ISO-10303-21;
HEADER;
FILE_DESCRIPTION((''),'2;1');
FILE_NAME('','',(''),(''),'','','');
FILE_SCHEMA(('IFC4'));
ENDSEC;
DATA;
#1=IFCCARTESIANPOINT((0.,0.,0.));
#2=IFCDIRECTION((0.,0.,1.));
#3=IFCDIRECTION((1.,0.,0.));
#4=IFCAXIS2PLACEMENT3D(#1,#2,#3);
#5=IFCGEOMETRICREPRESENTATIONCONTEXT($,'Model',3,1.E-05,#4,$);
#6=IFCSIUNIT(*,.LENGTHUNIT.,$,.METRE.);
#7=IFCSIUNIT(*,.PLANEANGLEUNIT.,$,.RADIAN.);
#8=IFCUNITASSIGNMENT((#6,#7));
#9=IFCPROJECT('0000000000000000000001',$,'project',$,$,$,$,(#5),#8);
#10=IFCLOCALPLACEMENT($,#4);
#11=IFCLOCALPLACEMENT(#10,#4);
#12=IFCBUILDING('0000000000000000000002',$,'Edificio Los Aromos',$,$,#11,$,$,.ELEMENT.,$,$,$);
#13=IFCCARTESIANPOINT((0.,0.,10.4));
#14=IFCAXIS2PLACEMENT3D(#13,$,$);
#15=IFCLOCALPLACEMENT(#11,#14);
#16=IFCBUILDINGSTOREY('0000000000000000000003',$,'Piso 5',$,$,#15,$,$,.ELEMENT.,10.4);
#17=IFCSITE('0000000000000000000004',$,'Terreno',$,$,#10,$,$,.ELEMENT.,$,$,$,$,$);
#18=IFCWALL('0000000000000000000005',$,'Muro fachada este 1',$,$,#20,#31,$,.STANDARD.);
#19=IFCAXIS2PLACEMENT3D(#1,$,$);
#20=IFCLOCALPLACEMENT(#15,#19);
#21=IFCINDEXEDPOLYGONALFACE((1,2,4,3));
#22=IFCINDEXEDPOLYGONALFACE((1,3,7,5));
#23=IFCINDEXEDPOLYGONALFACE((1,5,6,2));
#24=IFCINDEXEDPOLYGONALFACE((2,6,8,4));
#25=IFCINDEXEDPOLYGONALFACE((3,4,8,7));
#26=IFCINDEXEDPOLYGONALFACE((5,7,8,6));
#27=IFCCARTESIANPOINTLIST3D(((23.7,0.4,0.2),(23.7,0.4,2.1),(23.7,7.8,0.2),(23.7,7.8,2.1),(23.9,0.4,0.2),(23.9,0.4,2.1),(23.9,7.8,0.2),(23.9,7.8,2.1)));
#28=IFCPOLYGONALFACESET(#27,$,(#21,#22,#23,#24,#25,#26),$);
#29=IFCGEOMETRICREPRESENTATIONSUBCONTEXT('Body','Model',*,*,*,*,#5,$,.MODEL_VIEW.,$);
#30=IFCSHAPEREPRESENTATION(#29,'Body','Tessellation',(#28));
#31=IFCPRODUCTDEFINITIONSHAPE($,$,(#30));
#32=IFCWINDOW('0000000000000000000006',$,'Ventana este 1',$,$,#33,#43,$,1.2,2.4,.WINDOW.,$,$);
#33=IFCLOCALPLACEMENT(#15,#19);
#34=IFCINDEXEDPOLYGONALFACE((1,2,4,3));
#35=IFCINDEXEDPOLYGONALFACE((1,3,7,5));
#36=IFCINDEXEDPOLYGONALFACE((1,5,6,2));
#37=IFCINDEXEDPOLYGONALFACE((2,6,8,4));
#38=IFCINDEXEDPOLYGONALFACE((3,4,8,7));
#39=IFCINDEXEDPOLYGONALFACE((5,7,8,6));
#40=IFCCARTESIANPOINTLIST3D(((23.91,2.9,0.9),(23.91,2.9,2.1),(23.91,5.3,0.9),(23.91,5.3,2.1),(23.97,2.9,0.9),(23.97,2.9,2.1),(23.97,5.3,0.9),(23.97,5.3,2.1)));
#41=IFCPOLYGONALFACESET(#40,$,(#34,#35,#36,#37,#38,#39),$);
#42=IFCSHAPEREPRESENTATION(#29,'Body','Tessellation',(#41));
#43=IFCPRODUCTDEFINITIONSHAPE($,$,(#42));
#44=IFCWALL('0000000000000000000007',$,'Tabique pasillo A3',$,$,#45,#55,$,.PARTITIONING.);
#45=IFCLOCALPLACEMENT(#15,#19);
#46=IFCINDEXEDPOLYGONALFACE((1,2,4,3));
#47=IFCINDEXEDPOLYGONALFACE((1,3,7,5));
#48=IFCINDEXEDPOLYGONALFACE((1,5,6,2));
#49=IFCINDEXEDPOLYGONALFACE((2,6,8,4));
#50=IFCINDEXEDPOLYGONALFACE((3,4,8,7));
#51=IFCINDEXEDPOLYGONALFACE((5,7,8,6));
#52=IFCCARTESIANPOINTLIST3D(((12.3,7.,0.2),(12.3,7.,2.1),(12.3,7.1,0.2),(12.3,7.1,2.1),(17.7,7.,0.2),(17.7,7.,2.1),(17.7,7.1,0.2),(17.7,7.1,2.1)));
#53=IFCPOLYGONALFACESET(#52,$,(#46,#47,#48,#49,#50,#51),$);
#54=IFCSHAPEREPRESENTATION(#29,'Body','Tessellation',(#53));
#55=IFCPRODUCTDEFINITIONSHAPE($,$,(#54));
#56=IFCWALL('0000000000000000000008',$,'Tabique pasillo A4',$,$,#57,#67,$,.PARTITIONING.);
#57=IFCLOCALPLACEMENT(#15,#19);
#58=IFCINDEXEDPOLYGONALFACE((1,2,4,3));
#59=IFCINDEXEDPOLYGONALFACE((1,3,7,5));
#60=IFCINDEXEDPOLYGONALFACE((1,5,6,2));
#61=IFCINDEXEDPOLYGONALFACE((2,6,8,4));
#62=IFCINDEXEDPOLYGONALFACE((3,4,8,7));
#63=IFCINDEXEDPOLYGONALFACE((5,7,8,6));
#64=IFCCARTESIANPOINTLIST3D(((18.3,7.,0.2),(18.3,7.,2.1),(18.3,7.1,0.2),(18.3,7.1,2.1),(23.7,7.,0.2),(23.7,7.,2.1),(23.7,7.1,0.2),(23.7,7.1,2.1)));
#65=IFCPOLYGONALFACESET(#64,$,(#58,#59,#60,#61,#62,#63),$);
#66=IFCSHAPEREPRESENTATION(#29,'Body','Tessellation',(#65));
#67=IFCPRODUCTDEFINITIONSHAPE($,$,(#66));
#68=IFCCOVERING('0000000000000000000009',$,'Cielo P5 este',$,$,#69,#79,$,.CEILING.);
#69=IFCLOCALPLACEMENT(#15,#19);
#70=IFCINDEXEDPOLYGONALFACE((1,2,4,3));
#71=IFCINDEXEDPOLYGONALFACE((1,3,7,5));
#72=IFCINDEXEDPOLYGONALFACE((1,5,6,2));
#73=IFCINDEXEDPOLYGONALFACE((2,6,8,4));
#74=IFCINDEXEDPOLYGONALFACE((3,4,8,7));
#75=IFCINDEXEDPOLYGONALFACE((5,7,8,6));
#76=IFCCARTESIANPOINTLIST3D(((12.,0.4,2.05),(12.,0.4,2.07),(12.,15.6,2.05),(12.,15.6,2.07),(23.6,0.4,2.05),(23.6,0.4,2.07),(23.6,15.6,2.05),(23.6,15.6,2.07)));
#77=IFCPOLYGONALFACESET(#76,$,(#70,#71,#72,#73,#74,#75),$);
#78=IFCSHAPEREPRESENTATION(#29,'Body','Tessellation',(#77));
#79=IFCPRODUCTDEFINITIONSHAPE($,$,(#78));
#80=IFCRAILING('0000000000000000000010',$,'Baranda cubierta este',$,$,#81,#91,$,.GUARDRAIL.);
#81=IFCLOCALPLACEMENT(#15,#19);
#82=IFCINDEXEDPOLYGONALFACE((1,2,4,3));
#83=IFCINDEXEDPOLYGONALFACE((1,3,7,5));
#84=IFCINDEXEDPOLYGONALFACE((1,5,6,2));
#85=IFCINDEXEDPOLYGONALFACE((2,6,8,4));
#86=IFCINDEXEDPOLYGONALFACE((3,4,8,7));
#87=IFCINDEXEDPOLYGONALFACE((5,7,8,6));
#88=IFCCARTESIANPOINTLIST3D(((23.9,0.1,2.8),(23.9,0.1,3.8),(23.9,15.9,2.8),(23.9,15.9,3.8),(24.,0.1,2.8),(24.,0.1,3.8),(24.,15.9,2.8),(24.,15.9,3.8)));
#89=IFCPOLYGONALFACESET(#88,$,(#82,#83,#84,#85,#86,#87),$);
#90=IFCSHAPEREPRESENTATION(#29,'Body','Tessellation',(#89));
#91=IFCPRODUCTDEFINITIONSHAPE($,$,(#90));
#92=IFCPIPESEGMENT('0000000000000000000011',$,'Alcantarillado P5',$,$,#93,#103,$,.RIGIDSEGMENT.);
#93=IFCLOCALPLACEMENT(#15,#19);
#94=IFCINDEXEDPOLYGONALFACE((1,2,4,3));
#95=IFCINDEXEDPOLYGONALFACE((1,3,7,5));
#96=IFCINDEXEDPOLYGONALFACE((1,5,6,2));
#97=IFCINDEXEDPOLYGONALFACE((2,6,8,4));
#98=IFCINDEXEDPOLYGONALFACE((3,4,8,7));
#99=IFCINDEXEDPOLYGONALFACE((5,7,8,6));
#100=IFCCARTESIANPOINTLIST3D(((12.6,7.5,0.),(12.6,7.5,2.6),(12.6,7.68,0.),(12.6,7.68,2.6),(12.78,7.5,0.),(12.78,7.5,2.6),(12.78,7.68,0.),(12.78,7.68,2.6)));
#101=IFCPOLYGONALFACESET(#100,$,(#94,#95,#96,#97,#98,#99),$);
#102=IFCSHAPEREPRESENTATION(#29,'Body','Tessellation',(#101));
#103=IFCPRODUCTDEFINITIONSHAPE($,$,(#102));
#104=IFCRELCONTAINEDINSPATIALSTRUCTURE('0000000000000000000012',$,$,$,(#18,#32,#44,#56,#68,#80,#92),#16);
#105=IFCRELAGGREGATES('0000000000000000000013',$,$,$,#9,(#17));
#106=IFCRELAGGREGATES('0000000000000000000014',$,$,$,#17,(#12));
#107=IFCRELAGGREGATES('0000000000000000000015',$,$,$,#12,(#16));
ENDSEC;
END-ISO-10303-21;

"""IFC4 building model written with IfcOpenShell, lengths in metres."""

from ifc_helpers import new_model, si_unit, frame, frame_2d, origin_with_axes, place, context, subcontext, project, spatial, rectangle, extrude, element, save


model = new_model("IFC4")

# Units and contexts
model_context = context("Model", 3, precision=1e-05, world=origin_with_axes())
body_context = subcontext(model_context, "Body", "Model", "MODEL_VIEW")
ifc_project = project(units=[si_unit("LENGTHUNIT", "METRE"), si_unit("PLANEANGLEUNIT", "RADIAN")], contexts=[model_context])

# Site, building, storey
site_placement = place(None, origin_with_axes())
site = spatial("IfcSite", under=ifc_project, at=site_placement, Name="Terreno", CompositionType="ELEMENT")
building_placement = place(site_placement, origin_with_axes())
building = spatial("IfcBuilding", under=site, at=building_placement, Name="Edificio Los Aromos", CompositionType="ELEMENT")
storey_placement = place(building_placement, frame((0.0, 0.0, 10.4)))
storey = spatial("IfcBuildingStorey", under=building, at=storey_placement, Name="Piso 5", CompositionType="ELEMENT", Elevation=10.4)

# Wall
wall_1_placement = place(storey_placement, frame((23.7, 0.4, 0.2)))
element("IfcWall", 1, at=wall_1_placement, inside=storey, Name="Muro fachada este 1", PredefinedType="STANDARD", context=body_context, shape_type="SweptSolid", body=[
    extrude(rectangle(XDim=0.2, YDim=7.4, at=frame_2d((0.1, 3.7))), origin_with_axes(), (0.0, 0.0, 1.0), 1.9),
])

# Window
window_1_placement = place(storey_placement, frame((23.91, 2.9, 0.9)))
element("IfcWindow", 2, at=window_1_placement, inside=storey, Name="Ventana este 1", OverallHeight=1.2, OverallWidth=2.4, PredefinedType="WINDOW", context=body_context, shape_type="SweptSolid", body=[
    extrude(rectangle(XDim=0.06, YDim=2.4, at=frame_2d((0.03, 1.2))), origin_with_axes(), (0.0, 0.0, 1.0), 1.2),
])

# Walls
for number, where, name in (
    (3, (12.3, 7.0, 0.2), "Tabique pasillo A3"),
    (4, (18.3, 7.0, 0.2), "Tabique pasillo A4"),
):
    element("IfcWall", number, at=place(storey_placement, frame(where)), inside=storey, Name=name, PredefinedType="PARTITIONING", context=body_context, shape_type="SweptSolid", body=[
        extrude(rectangle(XDim=5.4, YDim=0.1, at=frame_2d((2.7, 0.05))), origin_with_axes(), (0.0, 0.0, 1.0), 1.9),
    ])

# Covering
covering_placement = place(storey_placement, frame((12.0, 0.4, 2.05)))
element("IfcCovering", 5, at=covering_placement, inside=storey, Name="Cielo P5 este", PredefinedType="CEILING", context=body_context, shape_type="SweptSolid", body=[
    extrude(rectangle(XDim=11.6, YDim=15.2, at=frame_2d((5.8, 7.6))), origin_with_axes(), (0.0, 0.0, 1.0), 0.02),
])

# Railing
railing_placement = place(storey_placement, frame((23.9, 0.1, 2.8)))
element("IfcRailing", 6, at=railing_placement, inside=storey, Name="Baranda cubierta este", PredefinedType="GUARDRAIL", context=body_context, shape_type="SweptSolid", body=[
    extrude(rectangle(XDim=0.1, YDim=15.8, at=frame_2d((0.05, 7.9))), origin_with_axes(), (0.0, 0.0, 1.0), 1.0),
])

# Pipe segment
pipe_segment_placement = place(storey_placement, frame((12.6, 7.5, 0.0)))
element("IfcPipeSegment", 7, at=pipe_segment_placement, inside=storey, Name="Alcantarillado P5", PredefinedType="RIGIDSEGMENT", context=body_context, shape_type="SweptSolid", body=[
    extrude(rectangle(XDim=0.18, YDim=0.18, at=frame_2d((0.09, 0.09))), origin_with_axes(), (0.0, 0.0, 1.0), 2.6),
])

save(model, "model.ifc")
